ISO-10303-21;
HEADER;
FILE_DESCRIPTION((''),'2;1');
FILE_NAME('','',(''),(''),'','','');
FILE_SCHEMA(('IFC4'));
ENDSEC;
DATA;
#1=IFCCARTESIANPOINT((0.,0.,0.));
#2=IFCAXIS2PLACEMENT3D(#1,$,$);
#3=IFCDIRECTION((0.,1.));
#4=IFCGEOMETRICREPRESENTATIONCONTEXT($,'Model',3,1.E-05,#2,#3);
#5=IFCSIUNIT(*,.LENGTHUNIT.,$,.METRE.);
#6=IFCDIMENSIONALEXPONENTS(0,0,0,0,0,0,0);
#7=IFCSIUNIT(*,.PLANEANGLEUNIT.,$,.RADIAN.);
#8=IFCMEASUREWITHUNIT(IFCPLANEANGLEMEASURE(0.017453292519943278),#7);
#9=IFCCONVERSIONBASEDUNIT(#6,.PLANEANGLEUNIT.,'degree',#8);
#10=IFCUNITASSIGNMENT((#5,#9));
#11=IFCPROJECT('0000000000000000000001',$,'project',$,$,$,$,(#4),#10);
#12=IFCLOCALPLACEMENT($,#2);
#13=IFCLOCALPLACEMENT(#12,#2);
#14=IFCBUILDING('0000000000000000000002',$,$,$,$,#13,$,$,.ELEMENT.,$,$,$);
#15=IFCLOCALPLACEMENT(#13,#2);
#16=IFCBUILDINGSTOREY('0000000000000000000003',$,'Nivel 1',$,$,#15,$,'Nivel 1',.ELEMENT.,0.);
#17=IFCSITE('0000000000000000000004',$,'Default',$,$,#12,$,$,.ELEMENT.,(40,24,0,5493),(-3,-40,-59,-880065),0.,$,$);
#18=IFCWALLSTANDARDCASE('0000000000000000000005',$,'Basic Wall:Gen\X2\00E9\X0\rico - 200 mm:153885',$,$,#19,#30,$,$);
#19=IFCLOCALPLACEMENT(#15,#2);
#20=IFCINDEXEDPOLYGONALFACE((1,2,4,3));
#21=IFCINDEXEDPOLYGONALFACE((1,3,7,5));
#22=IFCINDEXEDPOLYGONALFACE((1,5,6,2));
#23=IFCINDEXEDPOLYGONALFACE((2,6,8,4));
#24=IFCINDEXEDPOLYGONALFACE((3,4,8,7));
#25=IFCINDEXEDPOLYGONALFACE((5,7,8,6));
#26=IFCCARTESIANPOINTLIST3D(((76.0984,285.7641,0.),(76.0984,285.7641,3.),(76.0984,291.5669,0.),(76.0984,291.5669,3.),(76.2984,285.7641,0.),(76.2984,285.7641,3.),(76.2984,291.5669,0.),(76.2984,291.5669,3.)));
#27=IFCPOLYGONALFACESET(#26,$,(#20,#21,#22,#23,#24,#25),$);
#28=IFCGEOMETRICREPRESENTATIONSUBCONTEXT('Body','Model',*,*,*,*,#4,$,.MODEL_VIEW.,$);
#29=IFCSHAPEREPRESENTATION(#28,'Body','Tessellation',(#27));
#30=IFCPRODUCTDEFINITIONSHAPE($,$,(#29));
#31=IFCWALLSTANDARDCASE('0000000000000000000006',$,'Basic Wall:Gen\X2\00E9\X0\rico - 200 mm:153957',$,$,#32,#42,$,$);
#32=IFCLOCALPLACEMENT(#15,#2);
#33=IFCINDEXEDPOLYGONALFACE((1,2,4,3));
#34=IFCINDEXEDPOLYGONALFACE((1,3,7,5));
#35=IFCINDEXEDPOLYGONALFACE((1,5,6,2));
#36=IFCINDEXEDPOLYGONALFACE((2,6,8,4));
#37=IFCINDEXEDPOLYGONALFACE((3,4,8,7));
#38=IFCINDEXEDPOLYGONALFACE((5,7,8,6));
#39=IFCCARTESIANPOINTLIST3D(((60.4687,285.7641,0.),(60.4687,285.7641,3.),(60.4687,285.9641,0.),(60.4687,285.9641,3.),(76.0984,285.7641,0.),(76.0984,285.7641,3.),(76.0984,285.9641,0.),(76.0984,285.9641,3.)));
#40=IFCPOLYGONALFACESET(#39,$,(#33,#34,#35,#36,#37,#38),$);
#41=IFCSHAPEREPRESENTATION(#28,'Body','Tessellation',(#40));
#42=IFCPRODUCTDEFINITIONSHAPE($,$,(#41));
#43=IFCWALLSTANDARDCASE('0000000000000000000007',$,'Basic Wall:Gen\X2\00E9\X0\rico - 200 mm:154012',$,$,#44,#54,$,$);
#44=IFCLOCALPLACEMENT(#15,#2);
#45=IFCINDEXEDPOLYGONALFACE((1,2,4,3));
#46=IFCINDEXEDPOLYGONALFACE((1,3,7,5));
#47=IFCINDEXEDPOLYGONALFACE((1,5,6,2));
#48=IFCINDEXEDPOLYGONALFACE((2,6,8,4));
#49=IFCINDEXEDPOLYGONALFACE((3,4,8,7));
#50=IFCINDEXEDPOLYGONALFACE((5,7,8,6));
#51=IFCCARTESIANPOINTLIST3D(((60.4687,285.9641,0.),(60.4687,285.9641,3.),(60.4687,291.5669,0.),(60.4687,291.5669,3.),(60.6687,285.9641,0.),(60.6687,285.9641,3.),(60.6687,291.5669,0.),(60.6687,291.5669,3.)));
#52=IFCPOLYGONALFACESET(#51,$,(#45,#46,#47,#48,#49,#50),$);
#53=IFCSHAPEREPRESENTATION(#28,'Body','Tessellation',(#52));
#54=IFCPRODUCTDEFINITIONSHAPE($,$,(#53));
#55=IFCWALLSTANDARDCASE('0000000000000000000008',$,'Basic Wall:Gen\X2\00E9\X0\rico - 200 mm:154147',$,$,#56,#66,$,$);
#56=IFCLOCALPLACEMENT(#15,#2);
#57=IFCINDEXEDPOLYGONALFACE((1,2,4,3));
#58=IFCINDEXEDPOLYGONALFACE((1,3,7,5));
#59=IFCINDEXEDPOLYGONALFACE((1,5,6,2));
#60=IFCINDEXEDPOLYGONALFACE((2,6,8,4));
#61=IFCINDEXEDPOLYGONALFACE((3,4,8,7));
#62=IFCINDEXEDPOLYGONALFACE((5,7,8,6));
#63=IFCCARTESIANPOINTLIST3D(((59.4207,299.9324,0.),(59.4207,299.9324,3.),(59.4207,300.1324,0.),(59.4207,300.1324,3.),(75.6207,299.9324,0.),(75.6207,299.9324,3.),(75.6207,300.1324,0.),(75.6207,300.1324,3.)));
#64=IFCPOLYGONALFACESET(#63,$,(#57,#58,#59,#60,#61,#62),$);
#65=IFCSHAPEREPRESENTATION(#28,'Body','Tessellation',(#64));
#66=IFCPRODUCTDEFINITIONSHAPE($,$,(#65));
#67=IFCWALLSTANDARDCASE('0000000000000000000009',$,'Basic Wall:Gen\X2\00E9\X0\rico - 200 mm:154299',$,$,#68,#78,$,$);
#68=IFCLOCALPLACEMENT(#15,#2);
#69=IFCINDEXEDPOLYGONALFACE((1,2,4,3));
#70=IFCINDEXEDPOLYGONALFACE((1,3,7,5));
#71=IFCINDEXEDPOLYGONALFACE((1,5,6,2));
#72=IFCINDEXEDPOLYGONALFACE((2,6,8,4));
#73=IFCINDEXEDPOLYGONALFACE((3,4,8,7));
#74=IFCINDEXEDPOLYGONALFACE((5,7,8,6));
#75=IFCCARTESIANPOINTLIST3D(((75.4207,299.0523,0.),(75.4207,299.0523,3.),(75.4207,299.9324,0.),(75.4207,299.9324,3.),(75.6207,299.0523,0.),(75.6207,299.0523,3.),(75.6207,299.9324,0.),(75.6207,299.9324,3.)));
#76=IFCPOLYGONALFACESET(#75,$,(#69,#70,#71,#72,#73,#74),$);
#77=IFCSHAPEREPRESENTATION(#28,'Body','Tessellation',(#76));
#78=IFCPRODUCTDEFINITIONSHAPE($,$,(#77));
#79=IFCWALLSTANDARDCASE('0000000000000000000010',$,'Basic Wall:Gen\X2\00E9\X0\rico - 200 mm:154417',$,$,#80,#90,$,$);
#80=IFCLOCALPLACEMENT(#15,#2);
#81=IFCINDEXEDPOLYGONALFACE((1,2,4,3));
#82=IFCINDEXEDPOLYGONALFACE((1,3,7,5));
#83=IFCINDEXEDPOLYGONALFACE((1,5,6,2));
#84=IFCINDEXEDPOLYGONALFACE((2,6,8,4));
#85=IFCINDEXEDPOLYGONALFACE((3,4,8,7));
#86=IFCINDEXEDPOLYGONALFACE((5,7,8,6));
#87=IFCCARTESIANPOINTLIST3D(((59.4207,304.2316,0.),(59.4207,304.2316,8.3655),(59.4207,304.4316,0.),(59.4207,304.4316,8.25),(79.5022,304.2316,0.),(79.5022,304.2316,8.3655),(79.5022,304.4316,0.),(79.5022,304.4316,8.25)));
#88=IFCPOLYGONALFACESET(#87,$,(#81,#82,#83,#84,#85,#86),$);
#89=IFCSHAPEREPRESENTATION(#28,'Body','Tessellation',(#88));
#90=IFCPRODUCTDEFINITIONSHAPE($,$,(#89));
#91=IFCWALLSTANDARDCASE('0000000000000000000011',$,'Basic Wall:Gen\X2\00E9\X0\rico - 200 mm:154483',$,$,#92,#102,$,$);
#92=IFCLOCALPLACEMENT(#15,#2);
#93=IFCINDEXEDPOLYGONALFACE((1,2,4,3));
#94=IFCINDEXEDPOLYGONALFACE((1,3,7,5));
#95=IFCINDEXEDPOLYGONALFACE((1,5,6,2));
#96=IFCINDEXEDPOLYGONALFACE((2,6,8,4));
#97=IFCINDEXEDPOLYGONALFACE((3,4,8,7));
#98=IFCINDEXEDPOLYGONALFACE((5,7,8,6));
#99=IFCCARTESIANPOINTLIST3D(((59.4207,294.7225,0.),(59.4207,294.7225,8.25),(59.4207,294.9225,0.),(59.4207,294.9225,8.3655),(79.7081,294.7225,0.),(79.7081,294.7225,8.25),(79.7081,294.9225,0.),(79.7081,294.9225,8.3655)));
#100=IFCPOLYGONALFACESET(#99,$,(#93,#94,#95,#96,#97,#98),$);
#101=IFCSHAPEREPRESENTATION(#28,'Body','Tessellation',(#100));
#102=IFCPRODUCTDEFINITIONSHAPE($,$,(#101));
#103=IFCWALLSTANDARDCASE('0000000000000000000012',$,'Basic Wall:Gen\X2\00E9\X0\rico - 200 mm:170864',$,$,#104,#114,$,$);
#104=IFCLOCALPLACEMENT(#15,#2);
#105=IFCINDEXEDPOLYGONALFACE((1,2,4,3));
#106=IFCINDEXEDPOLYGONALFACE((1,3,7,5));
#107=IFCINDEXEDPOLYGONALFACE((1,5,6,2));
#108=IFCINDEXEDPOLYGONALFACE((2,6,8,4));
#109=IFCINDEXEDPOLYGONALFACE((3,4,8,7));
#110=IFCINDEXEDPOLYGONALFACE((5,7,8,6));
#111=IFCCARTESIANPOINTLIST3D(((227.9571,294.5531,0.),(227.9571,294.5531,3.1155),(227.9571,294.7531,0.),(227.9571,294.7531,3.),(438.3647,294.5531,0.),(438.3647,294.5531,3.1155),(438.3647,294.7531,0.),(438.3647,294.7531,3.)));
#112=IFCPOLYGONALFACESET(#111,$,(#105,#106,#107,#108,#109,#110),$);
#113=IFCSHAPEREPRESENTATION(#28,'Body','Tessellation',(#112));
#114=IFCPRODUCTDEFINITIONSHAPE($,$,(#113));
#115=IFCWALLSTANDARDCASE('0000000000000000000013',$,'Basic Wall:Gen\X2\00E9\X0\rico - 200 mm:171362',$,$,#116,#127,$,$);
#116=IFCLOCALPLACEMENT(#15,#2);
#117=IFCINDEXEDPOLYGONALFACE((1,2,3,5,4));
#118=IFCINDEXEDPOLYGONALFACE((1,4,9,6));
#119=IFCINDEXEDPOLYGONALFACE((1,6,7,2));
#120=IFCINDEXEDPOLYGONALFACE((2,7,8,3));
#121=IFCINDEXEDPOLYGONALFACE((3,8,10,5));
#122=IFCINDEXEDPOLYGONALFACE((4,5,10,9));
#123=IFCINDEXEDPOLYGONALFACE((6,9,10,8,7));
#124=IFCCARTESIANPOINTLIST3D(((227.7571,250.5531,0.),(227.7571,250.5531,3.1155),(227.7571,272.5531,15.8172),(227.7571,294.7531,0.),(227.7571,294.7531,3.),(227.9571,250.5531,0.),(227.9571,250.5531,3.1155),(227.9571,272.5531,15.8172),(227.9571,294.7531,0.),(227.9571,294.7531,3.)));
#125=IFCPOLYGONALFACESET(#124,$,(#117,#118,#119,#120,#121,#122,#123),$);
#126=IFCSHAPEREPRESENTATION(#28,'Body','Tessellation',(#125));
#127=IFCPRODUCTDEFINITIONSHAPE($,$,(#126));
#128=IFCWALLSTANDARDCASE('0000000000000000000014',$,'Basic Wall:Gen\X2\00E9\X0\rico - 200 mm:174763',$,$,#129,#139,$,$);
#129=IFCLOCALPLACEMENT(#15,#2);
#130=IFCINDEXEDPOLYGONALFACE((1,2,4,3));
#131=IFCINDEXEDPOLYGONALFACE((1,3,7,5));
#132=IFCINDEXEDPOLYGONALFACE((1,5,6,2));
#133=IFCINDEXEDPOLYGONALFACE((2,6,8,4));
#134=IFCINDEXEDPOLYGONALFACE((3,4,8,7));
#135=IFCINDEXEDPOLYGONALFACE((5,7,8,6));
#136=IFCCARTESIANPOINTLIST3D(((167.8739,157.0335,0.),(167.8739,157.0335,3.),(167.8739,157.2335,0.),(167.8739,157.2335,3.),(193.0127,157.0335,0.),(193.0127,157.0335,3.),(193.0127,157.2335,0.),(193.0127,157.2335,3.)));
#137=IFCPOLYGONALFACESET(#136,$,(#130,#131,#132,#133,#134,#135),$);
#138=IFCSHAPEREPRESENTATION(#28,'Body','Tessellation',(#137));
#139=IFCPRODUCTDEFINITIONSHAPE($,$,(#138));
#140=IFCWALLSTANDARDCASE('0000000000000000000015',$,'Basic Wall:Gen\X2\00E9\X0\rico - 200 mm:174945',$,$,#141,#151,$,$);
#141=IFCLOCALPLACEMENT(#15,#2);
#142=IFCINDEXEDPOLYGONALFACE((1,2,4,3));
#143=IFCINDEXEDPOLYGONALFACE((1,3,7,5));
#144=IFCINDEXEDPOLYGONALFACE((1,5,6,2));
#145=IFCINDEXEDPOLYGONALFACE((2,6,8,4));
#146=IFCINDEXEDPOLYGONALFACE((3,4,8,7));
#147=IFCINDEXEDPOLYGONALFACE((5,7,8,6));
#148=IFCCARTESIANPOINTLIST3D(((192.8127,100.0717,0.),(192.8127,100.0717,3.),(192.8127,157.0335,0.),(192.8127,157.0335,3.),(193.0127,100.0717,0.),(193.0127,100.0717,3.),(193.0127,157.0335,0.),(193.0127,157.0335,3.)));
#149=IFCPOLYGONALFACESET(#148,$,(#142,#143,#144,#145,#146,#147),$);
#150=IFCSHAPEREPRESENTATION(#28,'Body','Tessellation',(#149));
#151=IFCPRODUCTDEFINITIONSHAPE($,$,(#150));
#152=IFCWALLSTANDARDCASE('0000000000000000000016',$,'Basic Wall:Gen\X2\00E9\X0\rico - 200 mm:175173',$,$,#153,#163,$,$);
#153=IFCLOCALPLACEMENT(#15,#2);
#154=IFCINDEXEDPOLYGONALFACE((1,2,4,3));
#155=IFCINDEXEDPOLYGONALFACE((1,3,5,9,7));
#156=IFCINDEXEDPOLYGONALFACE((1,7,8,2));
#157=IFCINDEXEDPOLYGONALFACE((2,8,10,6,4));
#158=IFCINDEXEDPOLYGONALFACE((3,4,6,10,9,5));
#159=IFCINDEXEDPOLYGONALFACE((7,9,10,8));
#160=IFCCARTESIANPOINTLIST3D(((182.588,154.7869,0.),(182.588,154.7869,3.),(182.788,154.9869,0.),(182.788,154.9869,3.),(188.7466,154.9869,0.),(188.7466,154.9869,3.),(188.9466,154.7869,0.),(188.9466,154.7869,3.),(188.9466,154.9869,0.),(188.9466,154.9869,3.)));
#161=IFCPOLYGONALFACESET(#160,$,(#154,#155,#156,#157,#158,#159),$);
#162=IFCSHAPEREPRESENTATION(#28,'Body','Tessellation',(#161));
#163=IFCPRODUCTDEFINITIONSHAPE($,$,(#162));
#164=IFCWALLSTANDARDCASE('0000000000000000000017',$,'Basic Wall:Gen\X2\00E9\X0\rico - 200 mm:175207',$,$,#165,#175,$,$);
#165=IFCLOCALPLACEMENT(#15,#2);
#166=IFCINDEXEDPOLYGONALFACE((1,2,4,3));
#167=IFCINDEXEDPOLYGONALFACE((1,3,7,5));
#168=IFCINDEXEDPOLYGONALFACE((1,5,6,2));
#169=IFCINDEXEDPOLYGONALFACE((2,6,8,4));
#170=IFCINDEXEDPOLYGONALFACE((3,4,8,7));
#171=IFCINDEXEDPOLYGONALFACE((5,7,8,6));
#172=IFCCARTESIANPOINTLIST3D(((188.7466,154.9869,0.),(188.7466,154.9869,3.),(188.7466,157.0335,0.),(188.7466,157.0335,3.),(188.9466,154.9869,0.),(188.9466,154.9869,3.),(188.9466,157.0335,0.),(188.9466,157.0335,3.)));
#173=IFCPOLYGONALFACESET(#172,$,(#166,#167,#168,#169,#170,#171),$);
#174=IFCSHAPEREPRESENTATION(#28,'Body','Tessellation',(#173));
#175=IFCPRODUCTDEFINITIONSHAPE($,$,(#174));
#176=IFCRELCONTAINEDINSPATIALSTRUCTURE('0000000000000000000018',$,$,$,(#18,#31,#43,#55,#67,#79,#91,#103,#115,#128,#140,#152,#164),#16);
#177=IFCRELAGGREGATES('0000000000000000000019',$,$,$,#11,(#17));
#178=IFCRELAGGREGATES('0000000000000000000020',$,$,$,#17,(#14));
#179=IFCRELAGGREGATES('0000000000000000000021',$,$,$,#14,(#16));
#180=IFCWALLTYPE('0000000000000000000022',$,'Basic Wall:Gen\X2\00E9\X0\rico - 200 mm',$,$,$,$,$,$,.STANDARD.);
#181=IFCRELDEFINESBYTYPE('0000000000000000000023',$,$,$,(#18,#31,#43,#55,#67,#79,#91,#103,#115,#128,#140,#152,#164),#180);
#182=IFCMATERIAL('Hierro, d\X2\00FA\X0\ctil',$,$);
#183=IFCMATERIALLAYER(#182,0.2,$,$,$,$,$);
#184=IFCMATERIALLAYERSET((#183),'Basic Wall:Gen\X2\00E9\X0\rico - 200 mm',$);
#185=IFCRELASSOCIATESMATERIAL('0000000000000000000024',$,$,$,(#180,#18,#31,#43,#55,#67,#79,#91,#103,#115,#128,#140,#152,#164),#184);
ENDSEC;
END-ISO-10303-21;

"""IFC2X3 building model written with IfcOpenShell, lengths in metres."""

from ifc_helpers import new_model, entity, si_unit, converted_unit, direction, frame, frame_2d, origin, place, context, subcontext, project, spatial, polyline, rectangle, outline, extrude, clip, bounded_halfspace, material, layer, layer_set, layer_usage, type_object, element, save


model = new_model("IFC2X3")

# Units and contexts
model_context = context("Model", 3, precision=1e-05, world=origin(), true_north=direction((0.0, 1.0)))
body_context = subcontext(model_context, "Body", "Model", "MODEL_VIEW")
ifc_project = project(units=[si_unit("LENGTHUNIT", "METRE"), converted_unit("PLANEANGLEUNIT", "degree", entity("IfcPlaneAngleMeasure", 0.017453292519943278), si_unit("PLANEANGLEUNIT", "RADIAN"), dimensions=[0, 0, 0, 0, 0, 0, 0])], contexts=[model_context])

# Site, building, storey
site_placement = place(None, origin())
site = spatial("IfcSite", under=ifc_project, at=site_placement, Name="Default", CompositionType="ELEMENT", RefLatitude=(40, 24, 0, 5493), RefLongitude=(-3, -40, -59, -880065), RefElevation=0.0)
building_placement = place(site_placement, origin())
building = spatial("IfcBuilding", under=site, at=building_placement, CompositionType="ELEMENT")
storey_placement = place(building_placement, origin())
storey = spatial("IfcBuildingStorey", under=building, at=storey_placement, Name="Nivel 1", LongName="Nivel 1", CompositionType="ELEMENT", Elevation=0.0)

# Walls
ifc_material_1 = material(Name="Hierro, dúctil")
ifc_layer_1 = layer(ifc_material_1, 0.2)
ifc_layer_set_1 = layer_set([ifc_layer_1], Name="Basic Wall:Genérico - 200 mm")
ifc_layer_usage_1 = layer_usage(ifc_layer_set_1, "AXIS2", "NEGATIVE", 0.1)
wall_type = type_object("IfcWallType", Name="Basic Wall:Genérico - 200 mm", PredefinedType="STANDARD", material=ifc_layer_set_1)
wall_1_placement = place(storey_placement, frame((76.1984, 291.5669, 0.0), z_axis=(0.0, 0.0, 1.0), x_axis=(0.0, -1.0, 0.0)))
element("IfcWallStandardCase", 1, at=wall_1_placement, inside=storey, type_object=wall_type, material=ifc_layer_usage_1, Name="Basic Wall:Genérico - 200 mm:153885", context=body_context, shape_type="SweptSolid", body=[
    extrude(rectangle(XDim=5.8029, YDim=0.2, at=frame_2d((2.9014, 0.0), x_axis=(-1.0, 0.0))), origin(), (0.0, 0.0, 1.0), 3.0),
])
ifc_layer_usage_2 = layer_usage(ifc_layer_set_1, "AXIS2", "NEGATIVE", 0.1)
wall_2_placement = place(storey_placement, frame((76.0984, 285.8641, 0.0), z_axis=(0.0, 0.0, 1.0), x_axis=(-1.0, 0.0, 0.0)))
element("IfcWallStandardCase", 2, at=wall_2_placement, inside=storey, type_object=wall_type, material=ifc_layer_usage_2, Name="Basic Wall:Genérico - 200 mm:153957", context=body_context, shape_type="SweptSolid", body=[
    extrude(rectangle(XDim=15.6297, YDim=0.2, at=frame_2d((7.8148, 0.0), x_axis=(-1.0, 0.0))), origin(), (0.0, 0.0, 1.0), 3.0),
])
ifc_layer_usage_3 = layer_usage(ifc_layer_set_1, "AXIS2", "NEGATIVE", 0.1)
wall_3_placement = place(storey_placement, frame((60.5687, 285.9641, 0.0), z_axis=(0.0, 0.0, 1.0), x_axis=(0.0, 1.0, 0.0)))
element("IfcWallStandardCase", 3, at=wall_3_placement, inside=storey, type_object=wall_type, material=ifc_layer_usage_3, Name="Basic Wall:Genérico - 200 mm:154012", context=body_context, shape_type="SweptSolid", body=[
    extrude(rectangle(XDim=5.6029, YDim=0.2, at=frame_2d((2.8014, 0.0), x_axis=(-1.0, 0.0))), origin(), (0.0, 0.0, 1.0), 3.0),
])
ifc_layer_usage_4 = layer_usage(ifc_layer_set_1, "AXIS2", "NEGATIVE", 0.1)
wall_4_placement = place(storey_placement, frame((75.6207, 300.0324, 0.0), z_axis=(0.0, 0.0, 1.0), x_axis=(-1.0, 0.0, 0.0)))
element("IfcWallStandardCase", 4, at=wall_4_placement, inside=storey, type_object=wall_type, material=ifc_layer_usage_4, Name="Basic Wall:Genérico - 200 mm:154147", context=body_context, shape_type="SweptSolid", body=[
    extrude(rectangle(XDim=16.2, YDim=0.2, at=frame_2d((8.1, 0.0), x_axis=(-1.0, 0.0))), origin(), (0.0, 0.0, 1.0), 3.0),
])
ifc_layer_usage_5 = layer_usage(ifc_layer_set_1, "AXIS2", "NEGATIVE", 0.1)
wall_5_placement = place(storey_placement, frame((75.5207, 299.0523, 0.0), z_axis=(0.0, 0.0, 1.0), x_axis=(0.0, 1.0, 0.0)))
element("IfcWallStandardCase", 5, at=wall_5_placement, inside=storey, type_object=wall_type, material=ifc_layer_usage_5, Name="Basic Wall:Genérico - 200 mm:154299", context=body_context, shape_type="SweptSolid", body=[
    extrude(rectangle(XDim=0.8801, YDim=0.2, at=frame_2d((0.44, 0.0), x_axis=(-1.0, 0.0))), origin(), (0.0, 0.0, 1.0), 3.0),
])
ifc_layer_usage_6 = layer_usage(ifc_layer_set_1, "AXIS2", "NEGATIVE", 0.1)
wall_6_placement = place(storey_placement, frame((79.5022, 304.3316, 0.0), z_axis=(0.0, 0.0, 1.0), x_axis=(-1.0, 0.0, 0.0)))
element("IfcWallStandardCase", 6, at=wall_6_placement, inside=storey, type_object=wall_type, material=ifc_layer_usage_6, Name="Basic Wall:Genérico - 200 mm:154417", context=body_context, shape_type="Clipping", body=[
    clip(extrude(rectangle(XDim=20.0815, YDim=0.2, at=frame_2d((10.0408, 0.0), x_axis=(-1.0, 0.0))), origin(), (0.0, 0.0, 1.0), 8.3655), bounded_halfspace(frame((0.0, -0.1, 8.25), z_axis=(0.0, -0.5, 0.866025), x_axis=(1.0, 0.0, 0.0)), False, frame((0.0, -0.1, 8.25)), polyline([(0.0, 0.0), (20.0815, 0.0), (20.0815, 0.2), (19.8815, 0.2), (0.0, 0.2), (0.0, 0.0)]))),
])
ifc_layer_usage_7 = layer_usage(ifc_layer_set_1, "AXIS2", "NEGATIVE", 0.1)
wall_7_placement = place(storey_placement, frame((79.7081, 294.8225, 0.0), z_axis=(0.0, 0.0, 1.0), x_axis=(-1.0, 0.0, 0.0)))
element("IfcWallStandardCase", 7, at=wall_7_placement, inside=storey, type_object=wall_type, material=ifc_layer_usage_7, Name="Basic Wall:Genérico - 200 mm:154483", context=body_context, shape_type="Clipping", body=[
    clip(extrude(rectangle(XDim=20.2874, YDim=0.2, at=frame_2d((10.1437, 0.0), x_axis=(-1.0, 0.0))), origin(), (0.0, 0.0, 1.0), 8.3655), bounded_halfspace(frame((0.0, -0.1, 8.3655), z_axis=(0.0, 0.5, 0.866025), x_axis=(-1.0, 0.0, 0.0)), False, frame((0.0, -0.1, 8.3655)), polyline([(0.0, 0.0), (0.2, 0.0), (20.0874, 0.0), (20.2874, 0.0), (20.2874, 0.2), (0.0, 0.2), (0.0, 0.0)]))),
])
ifc_layer_usage_8 = layer_usage(ifc_layer_set_1, "AXIS2", "NEGATIVE", 0.1)
wall_8_placement = place(storey_placement, frame((227.9571, 294.6531, 0.0)))
element("IfcWallStandardCase", 8, at=wall_8_placement, inside=storey, type_object=wall_type, material=ifc_layer_usage_8, Name="Basic Wall:Genérico - 200 mm:170864", context=body_context, shape_type="Clipping", body=[
    clip(extrude(rectangle(XDim=210.4076, YDim=0.2, at=frame_2d((105.2038, 0.0), x_axis=(-1.0, 0.0))), origin(), (0.0, 0.0, 1.0), 3.1155), bounded_halfspace(frame((0.0, -0.1, 3.1155), z_axis=(0.0, 0.5, 0.866025), x_axis=(-1.0, 0.0, 0.0)), False, frame((0.0, -0.1, 3.1155)), polyline([(0.0, 0.0), (210.2076, 0.0), (210.4076, 0.0), (210.4076, 0.2), (0.0, 0.2), (0.0, 0.0)]))),
])
ifc_layer_usage_9 = layer_usage(ifc_layer_set_1, "AXIS2", "NEGATIVE", 0.1)
wall_9_placement = place(storey_placement, frame((227.8571, 250.5531, 0.0), z_axis=(0.0, 0.0, 1.0), x_axis=(0.0, 1.0, 0.0)))
element("IfcWallStandardCase", 9, at=wall_9_placement, inside=storey, type_object=wall_type, material=ifc_layer_usage_9, Name="Basic Wall:Genérico - 200 mm:171362", context=body_context, shape_type="Clipping", body=[
    clip(clip(extrude(rectangle(XDim=44.2, YDim=0.2, at=frame_2d((22.1, 0.0), x_axis=(-1.0, 0.0))), origin(), (0.0, 0.0, 1.0), 15.8172), bounded_halfspace(frame((22.0, -0.1, 15.8172), z_axis=(0.5, 0.0, 0.866025), x_axis=(0.0, 1.0, 0.0)), False, frame((22.0, -0.1, 15.8172)), polyline([(0.0, 0.0), (22.0, 0.0), (22.2, 0.0), (22.2, 0.2), (0.0, 0.2), (0.0, 0.0)]))), bounded_halfspace(frame((0.0, -0.1, 3.1155), z_axis=(-0.5, 0.0, 0.866025), x_axis=(0.0, -1.0, 0.0)), False, frame((0.0, -0.1, 3.1155)), polyline([(0.0, 0.0), (22.0, 0.0), (22.0, 0.2), (0.0, 0.2), (0.0, 0.0)]))),
])
ifc_layer_usage_10 = layer_usage(ifc_layer_set_1, "AXIS2", "NEGATIVE", 0.1)
wall_10_placement = place(storey_placement, frame((167.8739, 157.1335, 0.0)))
element("IfcWallStandardCase", 10, at=wall_10_placement, inside=storey, type_object=wall_type, material=ifc_layer_usage_10, Name="Basic Wall:Genérico - 200 mm:174763", context=body_context, shape_type="SweptSolid", body=[
    extrude(rectangle(XDim=25.1388, YDim=0.2, at=frame_2d((12.5694, 0.0), x_axis=(-1.0, 0.0))), origin(), (0.0, 0.0, 1.0), 3.0),
])
ifc_layer_usage_11 = layer_usage(ifc_layer_set_1, "AXIS2", "NEGATIVE", 0.1)
wall_11_placement = place(storey_placement, frame((192.9127, 157.0335, 0.0), z_axis=(0.0, 0.0, 1.0), x_axis=(0.0, -1.0, 0.0)))
element("IfcWallStandardCase", 11, at=wall_11_placement, inside=storey, type_object=wall_type, material=ifc_layer_usage_11, Name="Basic Wall:Genérico - 200 mm:174945", context=body_context, shape_type="SweptSolid", body=[
    extrude(rectangle(XDim=56.9618, YDim=0.2, at=frame_2d((28.4809, 0.0), x_axis=(-1.0, 0.0))), origin(), (0.0, 0.0, 1.0), 3.0),
])
ifc_layer_usage_12 = layer_usage(ifc_layer_set_1, "AXIS2", "NEGATIVE", 0.1)
wall_12_placement = place(storey_placement, frame((182.588, 154.8869, 0.0)))
element("IfcWallStandardCase", 12, at=wall_12_placement, inside=storey, type_object=wall_type, material=ifc_layer_usage_12, Name="Basic Wall:Genérico - 200 mm:175173", context=body_context, shape_type="SweptSolid", body=[
    extrude(outline(polyline([(6.3586, -0.1), (6.3586, 0.1), (6.1586, 0.1), (0.2, 0.1), (0.0, -0.1), (6.3586, -0.1)])), origin(), (0.0, 0.0, 1.0), 3.0),
])
ifc_layer_usage_13 = layer_usage(ifc_layer_set_1, "AXIS2", "NEGATIVE", 0.1)
wall_13_placement = place(storey_placement, frame((188.8466, 154.9869, 0.0), z_axis=(0.0, 0.0, 1.0), x_axis=(0.0, 1.0, 0.0)))
element("IfcWallStandardCase", 13, at=wall_13_placement, inside=storey, type_object=wall_type, material=ifc_layer_usage_13, Name="Basic Wall:Genérico - 200 mm:175207", context=body_context, shape_type="SweptSolid", body=[
    extrude(rectangle(XDim=2.0466, YDim=0.2, at=frame_2d((1.0233, 0.0), x_axis=(-1.0, 0.0))), origin(), (0.0, 0.0, 1.0), 3.0),
])

save(model, "model.ifc")
